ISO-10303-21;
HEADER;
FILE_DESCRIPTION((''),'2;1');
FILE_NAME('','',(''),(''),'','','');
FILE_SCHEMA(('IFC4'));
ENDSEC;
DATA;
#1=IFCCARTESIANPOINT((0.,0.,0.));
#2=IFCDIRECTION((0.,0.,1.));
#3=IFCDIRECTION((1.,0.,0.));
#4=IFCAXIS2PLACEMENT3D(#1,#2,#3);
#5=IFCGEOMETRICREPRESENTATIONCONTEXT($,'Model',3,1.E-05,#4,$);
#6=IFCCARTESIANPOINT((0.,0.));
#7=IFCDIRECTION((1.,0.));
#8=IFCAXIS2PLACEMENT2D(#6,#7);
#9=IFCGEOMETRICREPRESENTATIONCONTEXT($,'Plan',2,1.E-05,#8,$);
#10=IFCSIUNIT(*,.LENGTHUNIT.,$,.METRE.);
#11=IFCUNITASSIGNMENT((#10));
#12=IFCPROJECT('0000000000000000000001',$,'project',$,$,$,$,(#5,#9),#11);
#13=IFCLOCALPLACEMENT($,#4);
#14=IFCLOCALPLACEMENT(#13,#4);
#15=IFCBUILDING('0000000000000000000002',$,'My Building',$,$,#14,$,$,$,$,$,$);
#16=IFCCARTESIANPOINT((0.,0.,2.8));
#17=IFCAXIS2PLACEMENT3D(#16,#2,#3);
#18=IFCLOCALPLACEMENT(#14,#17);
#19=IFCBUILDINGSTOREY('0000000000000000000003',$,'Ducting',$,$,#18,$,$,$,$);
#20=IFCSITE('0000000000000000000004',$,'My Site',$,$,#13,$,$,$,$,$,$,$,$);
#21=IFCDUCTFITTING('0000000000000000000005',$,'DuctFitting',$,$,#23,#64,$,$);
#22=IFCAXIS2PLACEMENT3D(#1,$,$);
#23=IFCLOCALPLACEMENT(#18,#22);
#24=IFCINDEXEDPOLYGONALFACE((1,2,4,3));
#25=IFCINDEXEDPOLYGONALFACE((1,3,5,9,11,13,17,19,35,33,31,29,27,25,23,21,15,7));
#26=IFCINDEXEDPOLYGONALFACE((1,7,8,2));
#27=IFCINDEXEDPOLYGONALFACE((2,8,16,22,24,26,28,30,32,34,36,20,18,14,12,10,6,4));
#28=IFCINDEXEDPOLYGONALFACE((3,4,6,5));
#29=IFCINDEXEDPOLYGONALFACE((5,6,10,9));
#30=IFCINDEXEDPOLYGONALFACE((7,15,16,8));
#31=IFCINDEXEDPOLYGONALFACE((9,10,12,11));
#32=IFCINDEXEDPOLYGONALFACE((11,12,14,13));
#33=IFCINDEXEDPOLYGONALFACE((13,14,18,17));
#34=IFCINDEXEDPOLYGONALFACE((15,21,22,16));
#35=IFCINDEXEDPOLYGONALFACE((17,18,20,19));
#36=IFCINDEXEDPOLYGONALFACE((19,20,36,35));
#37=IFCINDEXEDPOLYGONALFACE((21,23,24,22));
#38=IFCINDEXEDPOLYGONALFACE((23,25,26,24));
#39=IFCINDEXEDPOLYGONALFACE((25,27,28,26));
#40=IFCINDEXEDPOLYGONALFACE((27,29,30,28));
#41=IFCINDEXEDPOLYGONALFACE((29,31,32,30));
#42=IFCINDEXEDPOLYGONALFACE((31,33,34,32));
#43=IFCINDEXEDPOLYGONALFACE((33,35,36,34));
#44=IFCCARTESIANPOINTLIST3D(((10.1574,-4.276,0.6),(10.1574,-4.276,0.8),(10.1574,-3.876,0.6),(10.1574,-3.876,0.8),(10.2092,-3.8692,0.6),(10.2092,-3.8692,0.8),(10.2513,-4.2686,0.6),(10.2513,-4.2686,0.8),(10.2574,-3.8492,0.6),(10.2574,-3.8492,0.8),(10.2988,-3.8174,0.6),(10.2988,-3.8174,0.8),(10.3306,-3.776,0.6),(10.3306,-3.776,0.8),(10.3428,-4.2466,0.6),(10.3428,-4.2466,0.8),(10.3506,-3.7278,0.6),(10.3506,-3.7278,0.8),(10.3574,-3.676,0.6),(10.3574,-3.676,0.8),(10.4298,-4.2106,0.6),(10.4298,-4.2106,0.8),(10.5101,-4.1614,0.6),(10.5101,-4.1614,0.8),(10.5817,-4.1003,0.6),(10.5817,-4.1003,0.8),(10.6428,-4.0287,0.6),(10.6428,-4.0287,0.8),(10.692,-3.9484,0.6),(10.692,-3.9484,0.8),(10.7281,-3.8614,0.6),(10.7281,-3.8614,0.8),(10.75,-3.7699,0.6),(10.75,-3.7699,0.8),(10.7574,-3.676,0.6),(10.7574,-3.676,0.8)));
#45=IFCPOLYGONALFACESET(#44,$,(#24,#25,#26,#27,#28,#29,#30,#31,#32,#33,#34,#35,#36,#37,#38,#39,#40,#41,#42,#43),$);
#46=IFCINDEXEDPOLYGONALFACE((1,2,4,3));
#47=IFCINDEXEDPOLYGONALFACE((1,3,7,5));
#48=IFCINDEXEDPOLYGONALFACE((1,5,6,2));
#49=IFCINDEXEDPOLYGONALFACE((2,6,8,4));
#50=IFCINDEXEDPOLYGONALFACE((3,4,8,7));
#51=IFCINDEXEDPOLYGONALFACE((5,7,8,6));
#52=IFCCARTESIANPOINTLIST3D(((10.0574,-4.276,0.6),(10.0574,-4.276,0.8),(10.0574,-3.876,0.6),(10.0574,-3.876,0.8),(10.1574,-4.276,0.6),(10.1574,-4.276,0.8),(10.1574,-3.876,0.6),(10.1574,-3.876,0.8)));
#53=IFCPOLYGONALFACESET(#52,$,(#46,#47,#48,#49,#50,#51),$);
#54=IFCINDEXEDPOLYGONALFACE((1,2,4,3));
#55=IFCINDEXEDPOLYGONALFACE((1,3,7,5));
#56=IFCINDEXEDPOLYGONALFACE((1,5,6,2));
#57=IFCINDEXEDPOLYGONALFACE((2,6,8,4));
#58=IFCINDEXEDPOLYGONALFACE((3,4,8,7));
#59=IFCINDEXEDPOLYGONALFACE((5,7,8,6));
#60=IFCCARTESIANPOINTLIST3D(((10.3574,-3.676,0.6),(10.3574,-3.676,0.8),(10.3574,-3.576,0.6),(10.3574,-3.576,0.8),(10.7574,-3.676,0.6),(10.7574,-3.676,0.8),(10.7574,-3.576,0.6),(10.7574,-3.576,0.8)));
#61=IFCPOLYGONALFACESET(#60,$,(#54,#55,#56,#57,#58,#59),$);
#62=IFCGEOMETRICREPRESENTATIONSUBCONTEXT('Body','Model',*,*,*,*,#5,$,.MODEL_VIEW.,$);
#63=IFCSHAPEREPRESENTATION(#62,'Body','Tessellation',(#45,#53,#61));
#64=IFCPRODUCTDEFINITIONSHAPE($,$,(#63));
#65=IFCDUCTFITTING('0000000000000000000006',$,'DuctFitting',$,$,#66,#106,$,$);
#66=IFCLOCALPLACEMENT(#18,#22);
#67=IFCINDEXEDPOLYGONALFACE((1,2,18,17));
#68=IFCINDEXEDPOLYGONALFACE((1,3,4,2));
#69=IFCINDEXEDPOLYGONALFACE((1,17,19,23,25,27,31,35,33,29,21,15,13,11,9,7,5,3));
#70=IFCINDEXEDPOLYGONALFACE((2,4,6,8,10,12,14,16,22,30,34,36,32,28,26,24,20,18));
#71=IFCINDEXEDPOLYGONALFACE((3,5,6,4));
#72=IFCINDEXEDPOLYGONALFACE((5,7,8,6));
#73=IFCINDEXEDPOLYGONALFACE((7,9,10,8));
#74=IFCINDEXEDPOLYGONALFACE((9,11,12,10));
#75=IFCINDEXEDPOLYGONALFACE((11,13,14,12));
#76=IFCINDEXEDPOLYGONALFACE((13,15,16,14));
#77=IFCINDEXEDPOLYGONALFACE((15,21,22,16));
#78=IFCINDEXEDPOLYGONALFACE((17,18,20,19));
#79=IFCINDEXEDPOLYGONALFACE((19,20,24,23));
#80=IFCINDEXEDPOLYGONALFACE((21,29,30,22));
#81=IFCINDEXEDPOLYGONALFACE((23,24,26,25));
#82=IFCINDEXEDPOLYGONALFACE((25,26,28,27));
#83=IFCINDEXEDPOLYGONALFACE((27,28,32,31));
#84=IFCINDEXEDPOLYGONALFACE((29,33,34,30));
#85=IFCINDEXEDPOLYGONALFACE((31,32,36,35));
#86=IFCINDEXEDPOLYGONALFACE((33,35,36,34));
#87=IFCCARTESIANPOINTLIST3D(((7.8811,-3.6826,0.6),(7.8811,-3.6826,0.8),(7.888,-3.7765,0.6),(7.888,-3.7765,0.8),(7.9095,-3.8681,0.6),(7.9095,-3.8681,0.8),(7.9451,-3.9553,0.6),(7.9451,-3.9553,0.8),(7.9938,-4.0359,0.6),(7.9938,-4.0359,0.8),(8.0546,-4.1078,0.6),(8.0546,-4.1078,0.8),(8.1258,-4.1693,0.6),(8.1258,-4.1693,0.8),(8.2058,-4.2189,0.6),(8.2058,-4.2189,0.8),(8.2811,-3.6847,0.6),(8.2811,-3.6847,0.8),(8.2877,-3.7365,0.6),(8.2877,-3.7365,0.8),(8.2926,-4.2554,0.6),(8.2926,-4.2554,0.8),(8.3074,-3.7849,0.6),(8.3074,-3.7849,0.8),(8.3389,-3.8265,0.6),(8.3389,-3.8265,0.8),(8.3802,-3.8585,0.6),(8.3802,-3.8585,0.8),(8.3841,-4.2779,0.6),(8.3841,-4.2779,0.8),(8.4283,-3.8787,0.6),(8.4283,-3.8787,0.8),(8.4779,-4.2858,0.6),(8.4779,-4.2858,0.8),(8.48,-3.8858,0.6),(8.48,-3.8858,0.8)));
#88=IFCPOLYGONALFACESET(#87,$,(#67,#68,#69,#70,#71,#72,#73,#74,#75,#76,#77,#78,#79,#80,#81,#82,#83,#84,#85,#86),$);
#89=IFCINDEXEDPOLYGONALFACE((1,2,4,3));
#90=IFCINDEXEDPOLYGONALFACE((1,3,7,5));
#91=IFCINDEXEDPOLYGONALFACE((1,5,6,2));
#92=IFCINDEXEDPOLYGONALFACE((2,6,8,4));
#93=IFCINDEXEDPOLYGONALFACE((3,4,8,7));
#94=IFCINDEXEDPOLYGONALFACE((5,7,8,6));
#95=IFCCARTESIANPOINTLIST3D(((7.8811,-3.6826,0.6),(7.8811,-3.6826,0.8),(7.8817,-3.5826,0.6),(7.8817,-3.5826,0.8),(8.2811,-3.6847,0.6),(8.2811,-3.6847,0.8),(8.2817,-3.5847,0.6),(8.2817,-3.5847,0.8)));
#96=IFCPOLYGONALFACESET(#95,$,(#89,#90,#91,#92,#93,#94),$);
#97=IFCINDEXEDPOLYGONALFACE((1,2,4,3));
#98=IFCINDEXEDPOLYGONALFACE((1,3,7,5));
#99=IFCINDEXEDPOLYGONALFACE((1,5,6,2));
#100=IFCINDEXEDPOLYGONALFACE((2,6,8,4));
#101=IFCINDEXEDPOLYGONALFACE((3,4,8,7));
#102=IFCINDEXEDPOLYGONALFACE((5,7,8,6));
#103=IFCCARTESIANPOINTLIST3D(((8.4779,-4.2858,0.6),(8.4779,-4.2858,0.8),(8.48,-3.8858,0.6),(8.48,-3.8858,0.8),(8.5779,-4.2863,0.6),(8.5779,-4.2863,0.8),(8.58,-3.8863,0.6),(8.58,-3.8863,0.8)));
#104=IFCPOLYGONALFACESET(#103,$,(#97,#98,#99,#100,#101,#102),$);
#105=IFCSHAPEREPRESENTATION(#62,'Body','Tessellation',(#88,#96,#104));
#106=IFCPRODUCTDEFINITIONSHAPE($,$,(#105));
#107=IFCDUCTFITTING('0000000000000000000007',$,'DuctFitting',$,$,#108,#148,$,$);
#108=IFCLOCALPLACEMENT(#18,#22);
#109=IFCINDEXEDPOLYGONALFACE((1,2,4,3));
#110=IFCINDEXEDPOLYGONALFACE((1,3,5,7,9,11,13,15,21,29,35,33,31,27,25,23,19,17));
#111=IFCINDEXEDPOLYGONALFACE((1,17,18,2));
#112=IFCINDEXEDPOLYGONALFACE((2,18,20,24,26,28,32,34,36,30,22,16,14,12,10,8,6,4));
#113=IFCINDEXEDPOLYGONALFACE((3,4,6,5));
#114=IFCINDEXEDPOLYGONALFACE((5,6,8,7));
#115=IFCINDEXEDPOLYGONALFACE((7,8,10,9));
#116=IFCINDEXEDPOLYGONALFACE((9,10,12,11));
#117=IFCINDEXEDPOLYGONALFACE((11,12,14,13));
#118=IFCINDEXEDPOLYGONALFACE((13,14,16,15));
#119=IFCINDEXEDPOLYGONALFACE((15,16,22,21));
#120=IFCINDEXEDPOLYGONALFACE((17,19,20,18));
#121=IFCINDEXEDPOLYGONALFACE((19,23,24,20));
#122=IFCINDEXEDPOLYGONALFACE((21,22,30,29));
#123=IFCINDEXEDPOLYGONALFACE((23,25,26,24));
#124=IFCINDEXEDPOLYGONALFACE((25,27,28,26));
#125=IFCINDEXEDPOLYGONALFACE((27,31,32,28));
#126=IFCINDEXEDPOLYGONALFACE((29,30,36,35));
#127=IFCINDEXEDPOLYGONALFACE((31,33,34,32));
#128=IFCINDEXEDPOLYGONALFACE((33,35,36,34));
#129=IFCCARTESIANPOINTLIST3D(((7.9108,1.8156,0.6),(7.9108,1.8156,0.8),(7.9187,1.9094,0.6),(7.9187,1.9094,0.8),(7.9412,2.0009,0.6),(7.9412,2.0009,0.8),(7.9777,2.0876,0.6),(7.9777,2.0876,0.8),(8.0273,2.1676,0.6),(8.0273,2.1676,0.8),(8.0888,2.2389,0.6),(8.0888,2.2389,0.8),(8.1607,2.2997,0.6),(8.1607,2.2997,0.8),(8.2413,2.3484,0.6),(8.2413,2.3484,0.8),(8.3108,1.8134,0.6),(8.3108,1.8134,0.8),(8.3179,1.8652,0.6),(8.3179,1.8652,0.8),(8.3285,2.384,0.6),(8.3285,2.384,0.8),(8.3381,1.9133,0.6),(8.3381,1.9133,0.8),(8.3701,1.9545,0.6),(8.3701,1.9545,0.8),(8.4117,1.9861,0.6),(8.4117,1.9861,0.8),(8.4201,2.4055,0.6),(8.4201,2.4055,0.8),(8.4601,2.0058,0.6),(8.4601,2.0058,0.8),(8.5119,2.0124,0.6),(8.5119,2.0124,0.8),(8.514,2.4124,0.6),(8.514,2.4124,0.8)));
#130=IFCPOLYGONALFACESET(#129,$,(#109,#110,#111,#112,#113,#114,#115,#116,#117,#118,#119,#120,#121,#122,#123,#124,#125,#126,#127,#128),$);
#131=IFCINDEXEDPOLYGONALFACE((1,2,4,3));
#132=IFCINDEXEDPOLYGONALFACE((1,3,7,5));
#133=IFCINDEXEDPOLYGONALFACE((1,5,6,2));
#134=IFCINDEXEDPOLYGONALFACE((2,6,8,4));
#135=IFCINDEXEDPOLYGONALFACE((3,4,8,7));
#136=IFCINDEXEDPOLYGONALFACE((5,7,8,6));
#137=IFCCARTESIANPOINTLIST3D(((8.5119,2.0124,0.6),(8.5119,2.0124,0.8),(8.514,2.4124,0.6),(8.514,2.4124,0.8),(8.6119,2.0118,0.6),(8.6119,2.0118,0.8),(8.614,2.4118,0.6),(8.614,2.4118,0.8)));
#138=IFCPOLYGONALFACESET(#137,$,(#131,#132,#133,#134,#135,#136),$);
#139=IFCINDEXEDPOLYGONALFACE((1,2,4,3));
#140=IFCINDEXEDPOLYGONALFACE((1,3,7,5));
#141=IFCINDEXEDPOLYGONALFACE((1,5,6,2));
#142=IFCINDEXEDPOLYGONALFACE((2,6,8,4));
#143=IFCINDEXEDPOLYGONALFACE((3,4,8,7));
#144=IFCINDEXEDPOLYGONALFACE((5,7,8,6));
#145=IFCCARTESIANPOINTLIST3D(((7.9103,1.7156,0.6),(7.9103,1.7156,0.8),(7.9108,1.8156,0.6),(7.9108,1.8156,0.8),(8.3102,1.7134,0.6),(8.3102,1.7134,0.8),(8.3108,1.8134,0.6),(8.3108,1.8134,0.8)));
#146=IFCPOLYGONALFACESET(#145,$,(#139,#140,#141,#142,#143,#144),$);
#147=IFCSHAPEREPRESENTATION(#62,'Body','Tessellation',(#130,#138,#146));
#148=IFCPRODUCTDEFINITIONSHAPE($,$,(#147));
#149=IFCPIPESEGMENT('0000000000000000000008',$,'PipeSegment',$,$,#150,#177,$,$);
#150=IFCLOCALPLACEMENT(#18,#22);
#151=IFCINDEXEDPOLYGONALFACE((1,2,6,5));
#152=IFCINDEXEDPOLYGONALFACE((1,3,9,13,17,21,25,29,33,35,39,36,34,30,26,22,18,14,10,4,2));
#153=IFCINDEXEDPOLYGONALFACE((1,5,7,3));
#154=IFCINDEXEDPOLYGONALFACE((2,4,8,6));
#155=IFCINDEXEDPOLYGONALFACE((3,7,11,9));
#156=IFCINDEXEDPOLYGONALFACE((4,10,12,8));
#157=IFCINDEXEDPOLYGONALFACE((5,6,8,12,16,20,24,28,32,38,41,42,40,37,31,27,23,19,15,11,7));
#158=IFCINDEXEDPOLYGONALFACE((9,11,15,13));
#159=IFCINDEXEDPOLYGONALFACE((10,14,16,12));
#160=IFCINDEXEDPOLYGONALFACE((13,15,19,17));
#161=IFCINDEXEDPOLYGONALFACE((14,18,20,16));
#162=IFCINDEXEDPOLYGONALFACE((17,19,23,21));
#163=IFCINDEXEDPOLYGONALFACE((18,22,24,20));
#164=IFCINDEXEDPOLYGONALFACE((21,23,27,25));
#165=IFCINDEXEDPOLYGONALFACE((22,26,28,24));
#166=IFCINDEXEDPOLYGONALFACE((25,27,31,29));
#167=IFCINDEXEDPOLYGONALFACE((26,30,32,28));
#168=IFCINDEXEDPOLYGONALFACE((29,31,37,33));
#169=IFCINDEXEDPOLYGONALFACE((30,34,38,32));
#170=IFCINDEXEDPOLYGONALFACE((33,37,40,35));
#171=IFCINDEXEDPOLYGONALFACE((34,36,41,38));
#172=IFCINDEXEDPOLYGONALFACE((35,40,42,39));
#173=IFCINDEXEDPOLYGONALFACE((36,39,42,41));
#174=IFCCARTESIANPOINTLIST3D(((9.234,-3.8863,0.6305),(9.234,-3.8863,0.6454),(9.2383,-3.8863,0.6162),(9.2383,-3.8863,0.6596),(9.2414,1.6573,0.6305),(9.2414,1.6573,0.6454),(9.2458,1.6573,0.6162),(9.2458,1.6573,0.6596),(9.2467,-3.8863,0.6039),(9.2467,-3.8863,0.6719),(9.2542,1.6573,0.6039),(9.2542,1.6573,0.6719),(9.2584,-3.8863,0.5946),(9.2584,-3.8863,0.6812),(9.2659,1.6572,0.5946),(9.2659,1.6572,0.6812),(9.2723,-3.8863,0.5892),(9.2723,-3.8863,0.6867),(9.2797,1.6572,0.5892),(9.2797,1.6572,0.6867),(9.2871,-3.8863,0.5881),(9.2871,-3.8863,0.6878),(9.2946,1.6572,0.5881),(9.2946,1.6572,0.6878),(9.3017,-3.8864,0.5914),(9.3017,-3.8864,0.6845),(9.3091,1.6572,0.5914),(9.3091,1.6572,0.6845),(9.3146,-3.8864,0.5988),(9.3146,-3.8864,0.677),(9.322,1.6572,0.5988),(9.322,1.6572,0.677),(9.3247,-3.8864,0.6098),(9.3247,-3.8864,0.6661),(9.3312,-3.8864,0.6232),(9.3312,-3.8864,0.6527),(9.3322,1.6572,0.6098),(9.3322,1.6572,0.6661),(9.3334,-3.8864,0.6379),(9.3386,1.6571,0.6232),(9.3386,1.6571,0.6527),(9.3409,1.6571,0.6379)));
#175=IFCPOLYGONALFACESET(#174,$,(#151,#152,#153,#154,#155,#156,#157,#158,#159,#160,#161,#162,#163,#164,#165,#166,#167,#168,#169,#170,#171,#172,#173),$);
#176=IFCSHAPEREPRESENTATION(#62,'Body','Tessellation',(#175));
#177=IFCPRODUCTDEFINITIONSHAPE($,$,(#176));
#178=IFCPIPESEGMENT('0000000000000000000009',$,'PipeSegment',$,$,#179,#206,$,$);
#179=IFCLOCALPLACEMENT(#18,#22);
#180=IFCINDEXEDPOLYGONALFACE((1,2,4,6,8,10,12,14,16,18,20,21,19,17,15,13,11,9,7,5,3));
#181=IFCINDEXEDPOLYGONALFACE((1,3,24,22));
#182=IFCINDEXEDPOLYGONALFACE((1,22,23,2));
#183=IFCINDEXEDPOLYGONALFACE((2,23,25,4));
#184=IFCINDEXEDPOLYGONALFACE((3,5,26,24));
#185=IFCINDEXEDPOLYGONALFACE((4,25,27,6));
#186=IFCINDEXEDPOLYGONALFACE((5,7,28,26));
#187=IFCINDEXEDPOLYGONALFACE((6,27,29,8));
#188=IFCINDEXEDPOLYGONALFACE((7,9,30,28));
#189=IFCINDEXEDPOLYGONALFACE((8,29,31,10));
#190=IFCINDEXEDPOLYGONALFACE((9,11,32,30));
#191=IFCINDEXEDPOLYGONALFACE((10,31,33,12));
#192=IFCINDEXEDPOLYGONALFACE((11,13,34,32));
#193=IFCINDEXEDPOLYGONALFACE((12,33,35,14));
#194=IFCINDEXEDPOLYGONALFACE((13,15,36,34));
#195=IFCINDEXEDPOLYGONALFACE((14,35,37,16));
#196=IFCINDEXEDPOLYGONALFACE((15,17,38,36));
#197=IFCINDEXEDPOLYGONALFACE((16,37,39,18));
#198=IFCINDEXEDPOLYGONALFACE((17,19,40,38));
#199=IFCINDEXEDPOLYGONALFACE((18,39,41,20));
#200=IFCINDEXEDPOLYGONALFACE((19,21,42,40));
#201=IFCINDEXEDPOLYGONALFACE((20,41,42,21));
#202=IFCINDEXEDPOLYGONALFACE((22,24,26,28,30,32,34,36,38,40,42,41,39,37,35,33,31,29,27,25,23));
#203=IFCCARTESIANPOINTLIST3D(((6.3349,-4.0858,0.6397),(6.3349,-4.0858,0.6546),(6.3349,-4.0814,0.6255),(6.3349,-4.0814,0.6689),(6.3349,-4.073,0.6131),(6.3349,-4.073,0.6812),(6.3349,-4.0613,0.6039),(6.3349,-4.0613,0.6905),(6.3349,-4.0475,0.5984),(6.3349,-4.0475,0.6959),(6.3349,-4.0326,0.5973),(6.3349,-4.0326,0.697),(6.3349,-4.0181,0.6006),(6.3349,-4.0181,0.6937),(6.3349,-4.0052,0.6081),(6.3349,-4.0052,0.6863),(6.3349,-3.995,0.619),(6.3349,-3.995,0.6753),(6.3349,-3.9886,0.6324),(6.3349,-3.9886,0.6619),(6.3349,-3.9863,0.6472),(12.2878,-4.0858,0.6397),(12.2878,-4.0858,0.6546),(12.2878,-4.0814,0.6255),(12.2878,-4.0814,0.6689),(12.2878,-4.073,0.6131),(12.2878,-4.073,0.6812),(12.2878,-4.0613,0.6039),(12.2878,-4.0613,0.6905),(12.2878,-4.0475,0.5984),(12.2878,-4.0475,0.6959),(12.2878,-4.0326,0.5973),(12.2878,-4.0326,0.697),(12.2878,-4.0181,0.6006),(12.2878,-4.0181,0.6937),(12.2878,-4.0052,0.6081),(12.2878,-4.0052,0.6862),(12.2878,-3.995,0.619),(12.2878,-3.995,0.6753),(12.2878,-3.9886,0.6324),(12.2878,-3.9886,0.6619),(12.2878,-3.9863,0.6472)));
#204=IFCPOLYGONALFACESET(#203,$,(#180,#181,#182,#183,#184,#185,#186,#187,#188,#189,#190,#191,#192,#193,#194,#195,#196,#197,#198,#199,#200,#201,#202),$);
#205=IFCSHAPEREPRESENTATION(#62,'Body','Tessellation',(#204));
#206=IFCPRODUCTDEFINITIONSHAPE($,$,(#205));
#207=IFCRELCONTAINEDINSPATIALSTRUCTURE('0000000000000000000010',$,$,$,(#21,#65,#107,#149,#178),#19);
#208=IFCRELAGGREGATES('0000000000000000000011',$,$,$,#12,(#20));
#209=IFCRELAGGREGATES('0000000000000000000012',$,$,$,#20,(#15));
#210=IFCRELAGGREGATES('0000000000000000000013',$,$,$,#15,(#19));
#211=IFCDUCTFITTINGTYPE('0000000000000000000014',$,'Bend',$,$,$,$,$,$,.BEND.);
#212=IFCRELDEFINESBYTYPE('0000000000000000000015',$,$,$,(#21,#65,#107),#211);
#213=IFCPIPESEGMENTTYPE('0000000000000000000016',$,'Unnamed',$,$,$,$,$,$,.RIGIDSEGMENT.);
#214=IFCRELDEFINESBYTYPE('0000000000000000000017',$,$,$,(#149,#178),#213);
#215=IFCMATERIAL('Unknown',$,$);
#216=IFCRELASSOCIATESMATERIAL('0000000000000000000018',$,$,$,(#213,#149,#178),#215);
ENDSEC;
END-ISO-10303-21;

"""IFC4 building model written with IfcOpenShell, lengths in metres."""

from ifc_helpers import new_model, si_unit, frame, origin_with_axes, origin_2d_with_axis, place, context, subcontext, project, spatial, line, arc, indexed_curve, rectangle, circle, outline, extrude, source, transform, mapped, material, material_profile, profile_set, profile_usage, type_object, type_shapes, element, save


model = new_model("IFC4")

# Units and contexts
model_context = context("Model", 3, precision=1e-05, world=origin_with_axes())
plan_context = context("Plan", 2, precision=1e-05, world=origin_2d_with_axis())
body_context = subcontext(model_context, "Body", "Model", "MODEL_VIEW")
ifc_project = project(units=[si_unit("LENGTHUNIT", "METRE")], contexts=[model_context, plan_context])

# Site, building, storey
site_placement = place(None, origin_with_axes())
site = spatial("IfcSite", under=ifc_project, at=site_placement, Name="My Site")
building_placement = place(site_placement, origin_with_axes())
building = spatial("IfcBuilding", under=site, at=building_placement, Name="My Building")
storey_placement = place(building_placement, frame((0.0, 0.0, 2.8), z_axis=(0.0, 0.0, 1.0), x_axis=(1.0, 0.0, 0.0)))
storey = spatial("IfcBuildingStorey", under=building, at=storey_placement, Name="Ducting")

# Shared definitions
ifc_material = material(Name="Unknown")

# Duct fittings
duct_fitting_type = type_object("IfcDuctFittingType", Name="Bend", PredefinedType="BEND")
shared_shape_1 = source(origin_with_axes(), body_context, "Body", "SweptSolid", [
    extrude(outline(indexed_curve([(0.2, 0.0), (0.2586, -0.1414), (0.4, -0.2), (0.4, -0.6), (-0.0243, -0.4243), (-0.2, 0.0)], segments=[arc(1, 2, 3), line(3, 4), arc(4, 5, 6), line(6, 1)])), frame((0.0, -0.1, -0.1), z_axis=(0.0, -1.0, 0.0), x_axis=(1.0, 0.0, 0.0)), (0.0, 0.0, -1.0), 0.2),
    extrude(rectangle(XDim=0.4, YDim=0.2), origin_with_axes(), (0.0, 0.0, -1.0), 0.1),
    extrude(rectangle(XDim=0.4, YDim=0.2), frame((0.4, 0.0, -0.5), z_axis=(1.0, 0.0, -0.000001), x_axis=(0.000001, 0.0, 1.0)), (0.0, 0.0, 1.0), 0.1),
])
type_shapes(duct_fitting_type, [shared_shape_1])
for number, where, z_axis, x_axis, name in (
    (1, (10.0574, -4.076, 0.7), (-1.0, 0.0, 0.0), (0.0, 1.0, 0.0), "DuctFitting"),
    (2, (8.0817, -3.5837, 0.7), (0.005395, 0.999985, 0.0), (0.999985, -0.005395, 0.0), "DuctFitting"),
    (3, (8.6129, 2.2118, 0.7), (0.999985, -0.005394, 0.0), (-0.005394, -0.999985, 0.0), "DuctFitting"),
):
    element("IfcDuctFitting", number, at=place(storey_placement, frame(where, z_axis=z_axis, x_axis=x_axis)), inside=storey, type_object=duct_fitting_type, Name=name, context=body_context, shape_type="MappedRepresentation", body=[
        mapped(shared_shape_1, transform((0.0, 0.0, 0.0), x_axis=(1.0, 0.0, 0.0), y_axis=(0.0, 1.0, 0.0), z_axis=(0.0, 0.0, 1.0), scale=1.0)),
    ])

# Pipe segments
ifc_material_profile_1 = material_profile(ifc_material, circle(Radius=0.05))
ifc_profile_set_1 = profile_set([ifc_material_profile_1])
ifc_profile_usage_1 = profile_usage(ifc_profile_set_1, cardinal=5)
pipe_segment_type = type_object("IfcPipeSegmentType", Name="Unnamed", PredefinedType="RIGIDSEGMENT", material=ifc_profile_set_1)
pipe_segment_1_placement = place(storey_placement, frame((9.2909, 1.6572, 0.6379), z_axis=(-0.001348, -0.999999, 0.0), x_axis=(0.999999, -0.001348, 0.0)))
element("IfcPipeSegment", 4, at=pipe_segment_1_placement, inside=storey, type_object=pipe_segment_type, material=ifc_profile_usage_1, Name="PipeSegment", context=body_context, shape_type="SweptSolid", body=[
    extrude(circle(Radius=0.05), origin_with_axes(), (0.0, 0.0, 1.0), 5.5436),
])
ifc_profile_usage_2 = profile_usage(ifc_profile_set_1, cardinal=5)
pipe_segment_2_placement = place(storey_placement, frame((6.3349, -4.0363, 0.6472), z_axis=(1.0, 0.0, 0.0), x_axis=(0.0, 1.0, 0.0)))
element("IfcPipeSegment", 5, at=pipe_segment_2_placement, inside=storey, type_object=pipe_segment_type, material=ifc_profile_usage_2, Name="PipeSegment", context=body_context, shape_type="SweptSolid", body=[
    extrude(circle(Radius=0.05), origin_with_axes(), (0.0, 0.0, 1.0), 5.9529),
])

save(model, "model.ifc")
